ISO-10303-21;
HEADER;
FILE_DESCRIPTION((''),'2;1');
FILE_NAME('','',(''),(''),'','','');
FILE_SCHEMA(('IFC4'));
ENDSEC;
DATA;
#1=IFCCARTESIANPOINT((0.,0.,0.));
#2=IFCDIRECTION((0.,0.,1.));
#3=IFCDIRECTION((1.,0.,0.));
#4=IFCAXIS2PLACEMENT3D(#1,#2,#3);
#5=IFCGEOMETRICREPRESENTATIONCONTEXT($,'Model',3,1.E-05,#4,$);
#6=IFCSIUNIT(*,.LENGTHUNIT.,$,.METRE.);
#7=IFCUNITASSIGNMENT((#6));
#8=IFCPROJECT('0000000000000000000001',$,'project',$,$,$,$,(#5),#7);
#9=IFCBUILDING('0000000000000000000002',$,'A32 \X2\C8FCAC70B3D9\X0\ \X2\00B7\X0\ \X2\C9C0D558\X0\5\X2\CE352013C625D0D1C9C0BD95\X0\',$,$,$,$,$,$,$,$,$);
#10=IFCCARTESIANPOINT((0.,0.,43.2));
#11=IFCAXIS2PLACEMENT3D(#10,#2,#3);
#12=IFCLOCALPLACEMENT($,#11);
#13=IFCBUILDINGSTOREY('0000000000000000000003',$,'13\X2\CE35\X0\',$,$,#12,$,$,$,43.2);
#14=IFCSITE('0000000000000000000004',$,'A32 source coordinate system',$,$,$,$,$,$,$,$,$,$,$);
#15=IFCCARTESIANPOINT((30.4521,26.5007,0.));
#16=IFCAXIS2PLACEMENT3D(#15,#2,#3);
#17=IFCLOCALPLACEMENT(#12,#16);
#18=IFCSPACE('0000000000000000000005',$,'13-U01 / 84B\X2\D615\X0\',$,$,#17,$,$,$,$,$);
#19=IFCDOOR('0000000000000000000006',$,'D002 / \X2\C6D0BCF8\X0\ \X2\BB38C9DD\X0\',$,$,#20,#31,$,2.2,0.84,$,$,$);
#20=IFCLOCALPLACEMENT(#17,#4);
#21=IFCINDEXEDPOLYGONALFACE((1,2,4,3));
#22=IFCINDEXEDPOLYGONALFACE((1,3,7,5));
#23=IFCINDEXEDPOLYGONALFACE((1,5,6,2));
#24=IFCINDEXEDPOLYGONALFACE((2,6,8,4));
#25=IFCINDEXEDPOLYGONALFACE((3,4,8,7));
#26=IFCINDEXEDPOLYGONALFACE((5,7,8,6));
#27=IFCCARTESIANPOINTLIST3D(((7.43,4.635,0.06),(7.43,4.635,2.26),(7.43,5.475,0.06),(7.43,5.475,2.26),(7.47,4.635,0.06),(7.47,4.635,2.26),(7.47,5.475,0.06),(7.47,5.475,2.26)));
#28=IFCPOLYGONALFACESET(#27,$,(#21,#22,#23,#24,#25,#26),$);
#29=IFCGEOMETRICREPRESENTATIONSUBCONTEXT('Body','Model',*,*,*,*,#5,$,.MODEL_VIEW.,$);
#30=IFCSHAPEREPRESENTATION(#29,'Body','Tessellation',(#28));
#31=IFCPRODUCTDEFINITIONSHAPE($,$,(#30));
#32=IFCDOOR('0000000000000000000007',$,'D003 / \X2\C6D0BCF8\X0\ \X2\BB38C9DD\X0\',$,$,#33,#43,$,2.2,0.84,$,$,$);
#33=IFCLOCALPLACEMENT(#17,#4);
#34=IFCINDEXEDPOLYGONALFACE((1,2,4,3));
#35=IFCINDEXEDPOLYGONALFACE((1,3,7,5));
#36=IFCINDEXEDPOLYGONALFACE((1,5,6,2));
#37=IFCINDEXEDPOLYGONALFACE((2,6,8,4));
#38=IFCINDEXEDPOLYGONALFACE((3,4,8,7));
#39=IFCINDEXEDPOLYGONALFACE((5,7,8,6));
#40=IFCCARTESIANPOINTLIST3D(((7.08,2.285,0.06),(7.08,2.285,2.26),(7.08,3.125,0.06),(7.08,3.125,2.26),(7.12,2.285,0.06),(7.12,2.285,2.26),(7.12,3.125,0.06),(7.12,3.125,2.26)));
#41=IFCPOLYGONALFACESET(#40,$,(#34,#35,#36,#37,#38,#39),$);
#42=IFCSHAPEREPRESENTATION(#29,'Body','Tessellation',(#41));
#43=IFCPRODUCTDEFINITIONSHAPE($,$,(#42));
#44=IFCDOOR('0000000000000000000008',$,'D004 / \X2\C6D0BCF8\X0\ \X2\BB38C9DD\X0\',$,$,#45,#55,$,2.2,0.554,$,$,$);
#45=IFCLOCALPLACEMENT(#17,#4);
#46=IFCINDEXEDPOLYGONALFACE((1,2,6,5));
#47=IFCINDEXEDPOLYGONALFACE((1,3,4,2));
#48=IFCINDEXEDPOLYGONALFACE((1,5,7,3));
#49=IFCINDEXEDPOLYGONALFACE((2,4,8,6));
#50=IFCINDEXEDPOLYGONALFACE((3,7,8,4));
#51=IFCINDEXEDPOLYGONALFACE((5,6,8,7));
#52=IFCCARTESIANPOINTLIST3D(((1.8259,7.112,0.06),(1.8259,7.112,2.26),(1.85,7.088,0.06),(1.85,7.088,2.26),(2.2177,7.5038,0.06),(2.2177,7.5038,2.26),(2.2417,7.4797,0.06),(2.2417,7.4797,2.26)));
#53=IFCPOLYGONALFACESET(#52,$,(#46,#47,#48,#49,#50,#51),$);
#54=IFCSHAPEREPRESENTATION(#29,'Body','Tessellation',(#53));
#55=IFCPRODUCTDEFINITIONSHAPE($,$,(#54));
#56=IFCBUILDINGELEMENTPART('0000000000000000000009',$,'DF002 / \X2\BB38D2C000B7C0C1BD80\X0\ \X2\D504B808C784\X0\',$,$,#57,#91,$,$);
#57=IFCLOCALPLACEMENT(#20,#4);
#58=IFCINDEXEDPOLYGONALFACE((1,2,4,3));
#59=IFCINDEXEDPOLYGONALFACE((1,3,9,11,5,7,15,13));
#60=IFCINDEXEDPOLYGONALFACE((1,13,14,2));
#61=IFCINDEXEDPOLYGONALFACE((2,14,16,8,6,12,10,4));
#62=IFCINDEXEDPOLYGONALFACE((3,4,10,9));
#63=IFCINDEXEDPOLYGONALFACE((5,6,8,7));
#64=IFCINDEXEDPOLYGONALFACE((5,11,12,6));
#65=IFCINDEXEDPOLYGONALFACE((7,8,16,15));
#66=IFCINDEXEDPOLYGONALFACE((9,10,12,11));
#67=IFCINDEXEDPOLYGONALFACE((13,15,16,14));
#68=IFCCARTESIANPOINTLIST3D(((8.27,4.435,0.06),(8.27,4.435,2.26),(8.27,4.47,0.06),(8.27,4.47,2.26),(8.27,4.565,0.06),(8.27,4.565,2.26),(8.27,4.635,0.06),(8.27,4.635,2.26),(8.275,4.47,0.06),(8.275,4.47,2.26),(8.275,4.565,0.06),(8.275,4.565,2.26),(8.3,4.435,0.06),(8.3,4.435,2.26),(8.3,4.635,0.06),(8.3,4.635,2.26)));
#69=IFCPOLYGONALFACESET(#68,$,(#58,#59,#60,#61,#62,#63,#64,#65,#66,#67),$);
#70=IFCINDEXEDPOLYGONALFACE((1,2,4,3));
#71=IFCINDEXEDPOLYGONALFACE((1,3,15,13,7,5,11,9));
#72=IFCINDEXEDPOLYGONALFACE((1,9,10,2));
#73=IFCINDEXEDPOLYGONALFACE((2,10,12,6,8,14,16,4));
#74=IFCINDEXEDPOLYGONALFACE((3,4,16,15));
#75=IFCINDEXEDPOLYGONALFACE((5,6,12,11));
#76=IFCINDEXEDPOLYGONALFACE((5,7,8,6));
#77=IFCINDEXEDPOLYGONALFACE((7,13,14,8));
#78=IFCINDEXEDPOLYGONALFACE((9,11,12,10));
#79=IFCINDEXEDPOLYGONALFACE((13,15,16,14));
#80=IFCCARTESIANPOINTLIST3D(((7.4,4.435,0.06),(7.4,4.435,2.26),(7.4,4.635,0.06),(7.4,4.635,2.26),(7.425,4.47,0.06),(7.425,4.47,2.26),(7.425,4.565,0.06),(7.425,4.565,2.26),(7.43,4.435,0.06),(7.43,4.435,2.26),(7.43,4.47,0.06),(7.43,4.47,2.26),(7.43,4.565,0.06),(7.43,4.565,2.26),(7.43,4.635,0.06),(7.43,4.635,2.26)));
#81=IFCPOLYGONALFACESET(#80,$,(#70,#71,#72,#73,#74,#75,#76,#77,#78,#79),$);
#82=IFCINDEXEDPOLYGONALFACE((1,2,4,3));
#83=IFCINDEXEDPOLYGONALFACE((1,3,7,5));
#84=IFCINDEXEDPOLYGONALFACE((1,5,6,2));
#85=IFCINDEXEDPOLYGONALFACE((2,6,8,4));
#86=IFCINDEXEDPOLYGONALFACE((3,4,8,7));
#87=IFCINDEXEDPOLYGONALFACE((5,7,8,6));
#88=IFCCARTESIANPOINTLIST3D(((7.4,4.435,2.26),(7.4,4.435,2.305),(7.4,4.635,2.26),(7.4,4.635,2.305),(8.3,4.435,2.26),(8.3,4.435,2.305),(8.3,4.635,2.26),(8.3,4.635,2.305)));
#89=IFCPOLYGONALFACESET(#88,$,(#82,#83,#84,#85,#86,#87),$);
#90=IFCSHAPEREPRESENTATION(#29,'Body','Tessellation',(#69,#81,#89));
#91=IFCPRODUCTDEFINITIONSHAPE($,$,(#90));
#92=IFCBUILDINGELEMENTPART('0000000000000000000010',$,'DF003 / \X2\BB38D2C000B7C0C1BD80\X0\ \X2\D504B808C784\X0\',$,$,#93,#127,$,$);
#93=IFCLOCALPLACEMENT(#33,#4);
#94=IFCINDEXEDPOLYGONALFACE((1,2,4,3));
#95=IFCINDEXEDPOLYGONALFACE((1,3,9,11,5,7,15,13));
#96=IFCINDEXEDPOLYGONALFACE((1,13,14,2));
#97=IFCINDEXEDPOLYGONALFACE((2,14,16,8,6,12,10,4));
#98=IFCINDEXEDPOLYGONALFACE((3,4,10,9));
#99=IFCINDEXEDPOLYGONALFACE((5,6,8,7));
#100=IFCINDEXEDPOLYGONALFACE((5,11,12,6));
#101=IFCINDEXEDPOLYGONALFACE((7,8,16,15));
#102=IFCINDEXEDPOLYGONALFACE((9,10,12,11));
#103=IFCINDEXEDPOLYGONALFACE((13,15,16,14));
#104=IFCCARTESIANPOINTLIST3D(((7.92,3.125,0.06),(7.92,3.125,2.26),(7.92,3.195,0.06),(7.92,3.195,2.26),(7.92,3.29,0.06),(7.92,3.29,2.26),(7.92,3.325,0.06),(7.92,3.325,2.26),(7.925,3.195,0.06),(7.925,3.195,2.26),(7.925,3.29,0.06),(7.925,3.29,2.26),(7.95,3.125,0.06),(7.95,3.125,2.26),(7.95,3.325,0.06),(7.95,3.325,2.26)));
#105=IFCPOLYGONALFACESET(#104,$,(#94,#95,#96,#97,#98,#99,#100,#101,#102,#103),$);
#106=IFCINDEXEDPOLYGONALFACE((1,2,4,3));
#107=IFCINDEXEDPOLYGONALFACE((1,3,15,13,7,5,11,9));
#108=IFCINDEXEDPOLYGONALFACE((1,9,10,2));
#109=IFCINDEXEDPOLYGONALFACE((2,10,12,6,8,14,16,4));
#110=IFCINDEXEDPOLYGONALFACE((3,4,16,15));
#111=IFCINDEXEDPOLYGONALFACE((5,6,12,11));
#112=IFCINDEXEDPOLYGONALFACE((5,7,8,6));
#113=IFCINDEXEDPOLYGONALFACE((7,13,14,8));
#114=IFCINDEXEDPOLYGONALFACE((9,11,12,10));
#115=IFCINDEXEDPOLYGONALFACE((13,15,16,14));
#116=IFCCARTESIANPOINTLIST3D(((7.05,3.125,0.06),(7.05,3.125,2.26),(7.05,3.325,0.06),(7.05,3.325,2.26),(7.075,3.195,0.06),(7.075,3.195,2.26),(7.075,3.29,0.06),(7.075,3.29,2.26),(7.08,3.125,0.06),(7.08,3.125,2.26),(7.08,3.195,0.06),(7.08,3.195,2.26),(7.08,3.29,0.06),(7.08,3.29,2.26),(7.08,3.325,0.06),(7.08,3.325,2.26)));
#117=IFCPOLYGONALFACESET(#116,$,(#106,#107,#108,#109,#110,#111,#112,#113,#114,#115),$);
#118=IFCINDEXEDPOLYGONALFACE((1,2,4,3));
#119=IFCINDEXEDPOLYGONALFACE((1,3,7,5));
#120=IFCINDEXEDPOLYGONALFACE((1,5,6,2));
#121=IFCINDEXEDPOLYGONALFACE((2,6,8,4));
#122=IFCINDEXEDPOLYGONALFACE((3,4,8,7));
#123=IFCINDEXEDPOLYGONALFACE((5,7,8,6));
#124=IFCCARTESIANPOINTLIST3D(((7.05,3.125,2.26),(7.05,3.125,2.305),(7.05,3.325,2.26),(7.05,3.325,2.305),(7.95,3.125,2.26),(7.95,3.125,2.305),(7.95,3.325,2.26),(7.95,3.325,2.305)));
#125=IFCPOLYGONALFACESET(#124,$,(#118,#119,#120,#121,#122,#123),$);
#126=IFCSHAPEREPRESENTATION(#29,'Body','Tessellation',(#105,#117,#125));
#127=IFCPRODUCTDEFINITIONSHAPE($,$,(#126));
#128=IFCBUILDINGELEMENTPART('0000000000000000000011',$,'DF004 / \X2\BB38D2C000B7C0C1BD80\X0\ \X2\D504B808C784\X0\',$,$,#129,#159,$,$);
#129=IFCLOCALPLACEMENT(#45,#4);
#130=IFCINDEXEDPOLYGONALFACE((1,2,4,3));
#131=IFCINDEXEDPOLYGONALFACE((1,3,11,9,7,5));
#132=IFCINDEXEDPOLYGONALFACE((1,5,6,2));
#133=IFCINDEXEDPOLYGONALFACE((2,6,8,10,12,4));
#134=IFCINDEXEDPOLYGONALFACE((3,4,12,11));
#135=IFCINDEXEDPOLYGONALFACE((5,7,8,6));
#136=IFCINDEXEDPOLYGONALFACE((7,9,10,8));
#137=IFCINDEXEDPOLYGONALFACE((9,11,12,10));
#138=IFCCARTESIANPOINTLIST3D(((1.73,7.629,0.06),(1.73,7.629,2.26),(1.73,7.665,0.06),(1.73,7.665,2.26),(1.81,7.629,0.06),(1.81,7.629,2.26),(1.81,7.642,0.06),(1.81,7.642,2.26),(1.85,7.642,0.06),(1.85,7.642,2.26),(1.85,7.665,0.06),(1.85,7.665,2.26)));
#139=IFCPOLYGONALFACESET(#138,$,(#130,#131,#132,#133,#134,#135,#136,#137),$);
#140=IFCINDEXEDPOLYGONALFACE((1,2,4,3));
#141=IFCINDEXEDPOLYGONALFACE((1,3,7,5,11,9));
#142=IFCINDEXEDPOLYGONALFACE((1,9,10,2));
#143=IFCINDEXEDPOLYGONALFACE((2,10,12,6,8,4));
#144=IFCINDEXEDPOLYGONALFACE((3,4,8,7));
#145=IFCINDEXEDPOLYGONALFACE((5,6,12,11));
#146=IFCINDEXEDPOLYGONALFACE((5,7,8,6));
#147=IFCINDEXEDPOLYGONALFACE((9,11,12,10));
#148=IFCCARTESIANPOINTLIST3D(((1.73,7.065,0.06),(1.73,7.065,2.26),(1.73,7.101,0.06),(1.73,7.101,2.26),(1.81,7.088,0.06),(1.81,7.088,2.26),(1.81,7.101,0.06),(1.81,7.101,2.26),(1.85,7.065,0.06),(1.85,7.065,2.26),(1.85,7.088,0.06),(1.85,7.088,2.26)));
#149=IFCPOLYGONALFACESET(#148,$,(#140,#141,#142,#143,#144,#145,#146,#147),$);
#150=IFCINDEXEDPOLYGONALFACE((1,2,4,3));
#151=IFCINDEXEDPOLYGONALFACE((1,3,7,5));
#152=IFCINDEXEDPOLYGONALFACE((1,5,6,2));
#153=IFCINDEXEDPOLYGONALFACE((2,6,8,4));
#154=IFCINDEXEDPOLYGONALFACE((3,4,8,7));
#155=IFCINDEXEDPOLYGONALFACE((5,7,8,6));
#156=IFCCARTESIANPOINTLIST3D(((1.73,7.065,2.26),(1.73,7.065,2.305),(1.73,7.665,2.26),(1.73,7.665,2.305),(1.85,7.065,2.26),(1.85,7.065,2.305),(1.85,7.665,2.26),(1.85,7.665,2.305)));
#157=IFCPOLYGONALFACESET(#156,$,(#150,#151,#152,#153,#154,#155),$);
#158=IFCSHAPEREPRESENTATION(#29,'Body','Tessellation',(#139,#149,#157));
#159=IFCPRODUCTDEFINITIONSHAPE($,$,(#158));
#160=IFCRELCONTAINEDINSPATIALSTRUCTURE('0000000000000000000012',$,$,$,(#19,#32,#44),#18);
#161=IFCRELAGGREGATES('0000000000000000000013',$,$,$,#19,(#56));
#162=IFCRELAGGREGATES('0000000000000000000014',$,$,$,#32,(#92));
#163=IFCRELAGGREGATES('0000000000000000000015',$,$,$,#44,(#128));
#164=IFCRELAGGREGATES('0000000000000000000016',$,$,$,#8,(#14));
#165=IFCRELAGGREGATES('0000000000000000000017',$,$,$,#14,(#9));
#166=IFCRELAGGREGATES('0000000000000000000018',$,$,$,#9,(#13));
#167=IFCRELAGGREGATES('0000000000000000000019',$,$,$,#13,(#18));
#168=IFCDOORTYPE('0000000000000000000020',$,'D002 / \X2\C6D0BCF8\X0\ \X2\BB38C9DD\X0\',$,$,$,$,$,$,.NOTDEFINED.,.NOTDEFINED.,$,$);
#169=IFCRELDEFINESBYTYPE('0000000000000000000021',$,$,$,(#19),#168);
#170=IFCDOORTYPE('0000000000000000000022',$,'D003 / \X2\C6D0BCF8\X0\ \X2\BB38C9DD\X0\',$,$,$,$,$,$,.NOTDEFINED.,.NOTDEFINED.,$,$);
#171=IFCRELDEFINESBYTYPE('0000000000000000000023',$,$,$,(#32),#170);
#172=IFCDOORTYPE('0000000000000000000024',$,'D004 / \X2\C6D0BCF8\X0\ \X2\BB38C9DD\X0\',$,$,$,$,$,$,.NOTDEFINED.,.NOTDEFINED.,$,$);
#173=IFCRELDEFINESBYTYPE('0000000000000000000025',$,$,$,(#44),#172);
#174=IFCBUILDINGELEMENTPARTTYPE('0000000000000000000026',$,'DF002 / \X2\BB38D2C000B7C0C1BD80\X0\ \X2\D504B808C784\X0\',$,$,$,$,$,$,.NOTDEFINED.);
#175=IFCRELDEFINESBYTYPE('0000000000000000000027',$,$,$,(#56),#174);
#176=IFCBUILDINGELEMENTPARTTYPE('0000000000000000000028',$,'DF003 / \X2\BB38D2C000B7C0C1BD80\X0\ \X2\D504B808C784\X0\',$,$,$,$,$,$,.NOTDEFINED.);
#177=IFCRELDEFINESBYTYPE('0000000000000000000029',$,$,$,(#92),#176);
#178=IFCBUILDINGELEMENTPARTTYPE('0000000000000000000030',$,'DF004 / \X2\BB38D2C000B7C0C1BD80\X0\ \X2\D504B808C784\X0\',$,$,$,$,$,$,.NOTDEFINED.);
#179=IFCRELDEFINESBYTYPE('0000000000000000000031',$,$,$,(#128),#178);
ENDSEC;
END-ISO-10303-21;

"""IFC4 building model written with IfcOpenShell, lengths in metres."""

from ifc_helpers import new_model, si_unit, frame, origin, origin_with_axes, place, context, subcontext, project, spatial, polyline, outline, extrude, source, transform, mapped, type_object, type_shapes, element, aggregate, save


model = new_model("IFC4")

# Units and contexts
model_context = context("Model", 3, precision=1e-05, world=origin_with_axes())
body_context = subcontext(model_context, "Body", "Model", "MODEL_VIEW")
ifc_project = project(units=[si_unit("LENGTHUNIT", "METRE")], contexts=[model_context])

# Site, building, storey, space
storey_placement = place(None, frame((0.0, 0.0, 43.2), z_axis=(0.0, 0.0, 1.0), x_axis=(1.0, 0.0, 0.0)))
space_placement = place(storey_placement, frame((30.4521, 26.5007, 0.0), z_axis=(0.0, 0.0, 1.0), x_axis=(1.0, 0.0, 0.0)))
site = spatial("IfcSite", under=ifc_project, Name="A32 source coordinate system")
building = spatial("IfcBuilding", under=site, Name="A32 주거동 · 지하5층–옥탑지붕")
storey = spatial("IfcBuildingStorey", under=building, at=storey_placement, Name="13층", Elevation=43.2)
space = spatial("IfcSpace", under=storey, at=space_placement, Name="13-U01 / 84B형")

# Doors
door_type_1 = type_object("IfcDoorType", Name="D002 / 원본 문짝", OperationType="NOTDEFINED", PredefinedType="NOTDEFINED")
shared_shape_1 = source(origin(), body_context, "Body", "SweptSolid", [
    extrude(outline(polyline([(7.43, 4.635), (7.43, 5.475), (7.47, 5.475), (7.47, 4.635), (7.43, 4.635)])), frame((0.0, 0.0, 0.06)), (0.0, 0.0, 1.0), 2.2),
])
type_shapes(door_type_1, [shared_shape_1])
door_1_placement = place(space_placement, origin_with_axes())
door_1 = element("IfcDoor", 1, at=door_1_placement, inside=space, type_object=door_type_1, Name="D002 / 원본 문짝", OverallHeight=2.2, OverallWidth=0.84, context=body_context, shape_type="MappedRepresentation", body=[
    mapped(shared_shape_1, transform((0.0, 0.0, 0.0), scale=1.0)),
])
door_type_2 = type_object("IfcDoorType", Name="D003 / 원본 문짝", OperationType="NOTDEFINED", PredefinedType="NOTDEFINED")
shared_shape_2 = source(origin(), body_context, "Body", "SweptSolid", [
    extrude(outline(polyline([(7.12, 2.285), (7.08, 2.285), (7.08, 3.125), (7.12, 3.125), (7.12, 2.285)])), frame((0.0, 0.0, 0.06)), (0.0, 0.0, 1.0), 2.2),
])
type_shapes(door_type_2, [shared_shape_2])
door_2_placement = place(space_placement, origin_with_axes())
door_2 = element("IfcDoor", 2, at=door_2_placement, inside=space, type_object=door_type_2, Name="D003 / 원본 문짝", OverallHeight=2.2, OverallWidth=0.84, context=body_context, shape_type="MappedRepresentation", body=[
    mapped(shared_shape_2, transform((0.0, 0.0, 0.0), scale=1.0)),
])
door_type_3 = type_object("IfcDoorType", Name="D004 / 원본 문짝", OperationType="NOTDEFINED", PredefinedType="NOTDEFINED")
shared_shape_3 = source(origin(), body_context, "Body", "SweptSolid", [
    extrude(outline(polyline([(2.2177, 7.5038), (2.2417, 7.4797), (1.85, 7.088), (1.8259, 7.112), (2.2177, 7.5038)])), frame((0.0, 0.0, 0.06)), (0.0, 0.0, 1.0), 2.2),
])
type_shapes(door_type_3, [shared_shape_3])
door_3_placement = place(space_placement, origin_with_axes())
door_3 = element("IfcDoor", 3, at=door_3_placement, inside=space, type_object=door_type_3, Name="D004 / 원본 문짝", OverallHeight=2.2, OverallWidth=0.554, context=body_context, shape_type="MappedRepresentation", body=[
    mapped(shared_shape_3, transform((0.0, 0.0, 0.0), scale=1.0)),
])

# Building element parts
building_element_part_type_1 = type_object("IfcBuildingElementPartType", Name="DF002 / 문틀·상부 프레임", PredefinedType="NOTDEFINED")
shared_shape_4 = source(origin(), body_context, "Body", "SweptSolid", [
    extrude(outline(polyline([(8.3, 4.435), (8.27, 4.435), (8.27, 4.47), (8.275, 4.47), (8.275, 4.565), (8.27, 4.565), (8.27, 4.635), (8.3, 4.635), (8.3, 4.435)])), frame((0.0, 0.0, 0.06)), (0.0, 0.0, 1.0), 2.2),
    extrude(outline(polyline([(7.43, 4.635), (7.43, 4.565), (7.425, 4.565), (7.425, 4.47), (7.43, 4.47), (7.43, 4.435), (7.4, 4.435), (7.4, 4.635), (7.43, 4.635)])), frame((0.0, 0.0, 0.06)), (0.0, 0.0, 1.0), 2.2),
    extrude(outline(polyline([(7.4, 4.435), (7.4, 4.635), (8.3, 4.635), (8.3, 4.435), (7.4, 4.435)])), frame((0.0, 0.0, 2.26)), (0.0, 0.0, 1.0), 0.045),
])
type_shapes(building_element_part_type_1, [shared_shape_4])
building_element_part_1_placement = place(door_1_placement, origin_with_axes())
building_element_part_1 = element("IfcBuildingElementPart", 4, at=building_element_part_1_placement, type_object=building_element_part_type_1, Name="DF002 / 문틀·상부 프레임", context=body_context, shape_type="MappedRepresentation", body=[
    mapped(shared_shape_4, transform((0.0, 0.0, 0.0), scale=1.0)),
])
aggregate(door_1, [building_element_part_1])
building_element_part_type_2 = type_object("IfcBuildingElementPartType", Name="DF003 / 문틀·상부 프레임", PredefinedType="NOTDEFINED")
shared_shape_5 = source(origin(), body_context, "Body", "SweptSolid", [
    extrude(outline(polyline([(7.92, 3.125), (7.92, 3.195), (7.925, 3.195), (7.925, 3.29), (7.92, 3.29), (7.92, 3.325), (7.95, 3.325), (7.95, 3.125), (7.92, 3.125)])), frame((0.0, 0.0, 0.06)), (0.0, 0.0, 1.0), 2.2),
    extrude(outline(polyline([(7.05, 3.325), (7.08, 3.325), (7.08, 3.29), (7.075, 3.29), (7.075, 3.195), (7.08, 3.195), (7.08, 3.125), (7.05, 3.125), (7.05, 3.325)])), frame((0.0, 0.0, 0.06)), (0.0, 0.0, 1.0), 2.2),
    extrude(outline(polyline([(7.05, 3.125), (7.05, 3.325), (7.95, 3.325), (7.95, 3.125), (7.05, 3.125)])), frame((0.0, 0.0, 2.26)), (0.0, 0.0, 1.0), 0.045),
])
type_shapes(building_element_part_type_2, [shared_shape_5])
building_element_part_2_placement = place(door_2_placement, origin_with_axes())
building_element_part_2 = element("IfcBuildingElementPart", 5, at=building_element_part_2_placement, type_object=building_element_part_type_2, Name="DF003 / 문틀·상부 프레임", context=body_context, shape_type="MappedRepresentation", body=[
    mapped(shared_shape_5, transform((0.0, 0.0, 0.0), scale=1.0)),
])
aggregate(door_2, [building_element_part_2])
building_element_part_type_3 = type_object("IfcBuildingElementPartType", Name="DF004 / 문틀·상부 프레임", PredefinedType="NOTDEFINED")
shared_shape_6 = source(origin(), body_context, "Body", "SweptSolid", [
    extrude(outline(polyline([(1.85, 7.665), (1.85, 7.642), (1.81, 7.642), (1.81, 7.629), (1.73, 7.629), (1.73, 7.665), (1.85, 7.665)])), frame((0.0, 0.0, 0.06)), (0.0, 0.0, 1.0), 2.2),
    extrude(outline(polyline([(1.73, 7.101), (1.81, 7.101), (1.81, 7.088), (1.85, 7.088), (1.85, 7.065), (1.73, 7.065), (1.73, 7.101)])), frame((0.0, 0.0, 0.06)), (0.0, 0.0, 1.0), 2.2),
    extrude(outline(polyline([(1.73, 7.065), (1.73, 7.665), (1.85, 7.665), (1.85, 7.065), (1.73, 7.065)])), frame((0.0, 0.0, 2.26)), (0.0, 0.0, 1.0), 0.045),
])
type_shapes(building_element_part_type_3, [shared_shape_6])
building_element_part_3_placement = place(door_3_placement, origin_with_axes())
building_element_part_3 = element("IfcBuildingElementPart", 6, at=building_element_part_3_placement, type_object=building_element_part_type_3, Name="DF004 / 문틀·상부 프레임", context=body_context, shape_type="MappedRepresentation", body=[
    mapped(shared_shape_6, transform((0.0, 0.0, 0.0), scale=1.0)),
])
aggregate(door_3, [building_element_part_3])

save(model, "model.ifc")
